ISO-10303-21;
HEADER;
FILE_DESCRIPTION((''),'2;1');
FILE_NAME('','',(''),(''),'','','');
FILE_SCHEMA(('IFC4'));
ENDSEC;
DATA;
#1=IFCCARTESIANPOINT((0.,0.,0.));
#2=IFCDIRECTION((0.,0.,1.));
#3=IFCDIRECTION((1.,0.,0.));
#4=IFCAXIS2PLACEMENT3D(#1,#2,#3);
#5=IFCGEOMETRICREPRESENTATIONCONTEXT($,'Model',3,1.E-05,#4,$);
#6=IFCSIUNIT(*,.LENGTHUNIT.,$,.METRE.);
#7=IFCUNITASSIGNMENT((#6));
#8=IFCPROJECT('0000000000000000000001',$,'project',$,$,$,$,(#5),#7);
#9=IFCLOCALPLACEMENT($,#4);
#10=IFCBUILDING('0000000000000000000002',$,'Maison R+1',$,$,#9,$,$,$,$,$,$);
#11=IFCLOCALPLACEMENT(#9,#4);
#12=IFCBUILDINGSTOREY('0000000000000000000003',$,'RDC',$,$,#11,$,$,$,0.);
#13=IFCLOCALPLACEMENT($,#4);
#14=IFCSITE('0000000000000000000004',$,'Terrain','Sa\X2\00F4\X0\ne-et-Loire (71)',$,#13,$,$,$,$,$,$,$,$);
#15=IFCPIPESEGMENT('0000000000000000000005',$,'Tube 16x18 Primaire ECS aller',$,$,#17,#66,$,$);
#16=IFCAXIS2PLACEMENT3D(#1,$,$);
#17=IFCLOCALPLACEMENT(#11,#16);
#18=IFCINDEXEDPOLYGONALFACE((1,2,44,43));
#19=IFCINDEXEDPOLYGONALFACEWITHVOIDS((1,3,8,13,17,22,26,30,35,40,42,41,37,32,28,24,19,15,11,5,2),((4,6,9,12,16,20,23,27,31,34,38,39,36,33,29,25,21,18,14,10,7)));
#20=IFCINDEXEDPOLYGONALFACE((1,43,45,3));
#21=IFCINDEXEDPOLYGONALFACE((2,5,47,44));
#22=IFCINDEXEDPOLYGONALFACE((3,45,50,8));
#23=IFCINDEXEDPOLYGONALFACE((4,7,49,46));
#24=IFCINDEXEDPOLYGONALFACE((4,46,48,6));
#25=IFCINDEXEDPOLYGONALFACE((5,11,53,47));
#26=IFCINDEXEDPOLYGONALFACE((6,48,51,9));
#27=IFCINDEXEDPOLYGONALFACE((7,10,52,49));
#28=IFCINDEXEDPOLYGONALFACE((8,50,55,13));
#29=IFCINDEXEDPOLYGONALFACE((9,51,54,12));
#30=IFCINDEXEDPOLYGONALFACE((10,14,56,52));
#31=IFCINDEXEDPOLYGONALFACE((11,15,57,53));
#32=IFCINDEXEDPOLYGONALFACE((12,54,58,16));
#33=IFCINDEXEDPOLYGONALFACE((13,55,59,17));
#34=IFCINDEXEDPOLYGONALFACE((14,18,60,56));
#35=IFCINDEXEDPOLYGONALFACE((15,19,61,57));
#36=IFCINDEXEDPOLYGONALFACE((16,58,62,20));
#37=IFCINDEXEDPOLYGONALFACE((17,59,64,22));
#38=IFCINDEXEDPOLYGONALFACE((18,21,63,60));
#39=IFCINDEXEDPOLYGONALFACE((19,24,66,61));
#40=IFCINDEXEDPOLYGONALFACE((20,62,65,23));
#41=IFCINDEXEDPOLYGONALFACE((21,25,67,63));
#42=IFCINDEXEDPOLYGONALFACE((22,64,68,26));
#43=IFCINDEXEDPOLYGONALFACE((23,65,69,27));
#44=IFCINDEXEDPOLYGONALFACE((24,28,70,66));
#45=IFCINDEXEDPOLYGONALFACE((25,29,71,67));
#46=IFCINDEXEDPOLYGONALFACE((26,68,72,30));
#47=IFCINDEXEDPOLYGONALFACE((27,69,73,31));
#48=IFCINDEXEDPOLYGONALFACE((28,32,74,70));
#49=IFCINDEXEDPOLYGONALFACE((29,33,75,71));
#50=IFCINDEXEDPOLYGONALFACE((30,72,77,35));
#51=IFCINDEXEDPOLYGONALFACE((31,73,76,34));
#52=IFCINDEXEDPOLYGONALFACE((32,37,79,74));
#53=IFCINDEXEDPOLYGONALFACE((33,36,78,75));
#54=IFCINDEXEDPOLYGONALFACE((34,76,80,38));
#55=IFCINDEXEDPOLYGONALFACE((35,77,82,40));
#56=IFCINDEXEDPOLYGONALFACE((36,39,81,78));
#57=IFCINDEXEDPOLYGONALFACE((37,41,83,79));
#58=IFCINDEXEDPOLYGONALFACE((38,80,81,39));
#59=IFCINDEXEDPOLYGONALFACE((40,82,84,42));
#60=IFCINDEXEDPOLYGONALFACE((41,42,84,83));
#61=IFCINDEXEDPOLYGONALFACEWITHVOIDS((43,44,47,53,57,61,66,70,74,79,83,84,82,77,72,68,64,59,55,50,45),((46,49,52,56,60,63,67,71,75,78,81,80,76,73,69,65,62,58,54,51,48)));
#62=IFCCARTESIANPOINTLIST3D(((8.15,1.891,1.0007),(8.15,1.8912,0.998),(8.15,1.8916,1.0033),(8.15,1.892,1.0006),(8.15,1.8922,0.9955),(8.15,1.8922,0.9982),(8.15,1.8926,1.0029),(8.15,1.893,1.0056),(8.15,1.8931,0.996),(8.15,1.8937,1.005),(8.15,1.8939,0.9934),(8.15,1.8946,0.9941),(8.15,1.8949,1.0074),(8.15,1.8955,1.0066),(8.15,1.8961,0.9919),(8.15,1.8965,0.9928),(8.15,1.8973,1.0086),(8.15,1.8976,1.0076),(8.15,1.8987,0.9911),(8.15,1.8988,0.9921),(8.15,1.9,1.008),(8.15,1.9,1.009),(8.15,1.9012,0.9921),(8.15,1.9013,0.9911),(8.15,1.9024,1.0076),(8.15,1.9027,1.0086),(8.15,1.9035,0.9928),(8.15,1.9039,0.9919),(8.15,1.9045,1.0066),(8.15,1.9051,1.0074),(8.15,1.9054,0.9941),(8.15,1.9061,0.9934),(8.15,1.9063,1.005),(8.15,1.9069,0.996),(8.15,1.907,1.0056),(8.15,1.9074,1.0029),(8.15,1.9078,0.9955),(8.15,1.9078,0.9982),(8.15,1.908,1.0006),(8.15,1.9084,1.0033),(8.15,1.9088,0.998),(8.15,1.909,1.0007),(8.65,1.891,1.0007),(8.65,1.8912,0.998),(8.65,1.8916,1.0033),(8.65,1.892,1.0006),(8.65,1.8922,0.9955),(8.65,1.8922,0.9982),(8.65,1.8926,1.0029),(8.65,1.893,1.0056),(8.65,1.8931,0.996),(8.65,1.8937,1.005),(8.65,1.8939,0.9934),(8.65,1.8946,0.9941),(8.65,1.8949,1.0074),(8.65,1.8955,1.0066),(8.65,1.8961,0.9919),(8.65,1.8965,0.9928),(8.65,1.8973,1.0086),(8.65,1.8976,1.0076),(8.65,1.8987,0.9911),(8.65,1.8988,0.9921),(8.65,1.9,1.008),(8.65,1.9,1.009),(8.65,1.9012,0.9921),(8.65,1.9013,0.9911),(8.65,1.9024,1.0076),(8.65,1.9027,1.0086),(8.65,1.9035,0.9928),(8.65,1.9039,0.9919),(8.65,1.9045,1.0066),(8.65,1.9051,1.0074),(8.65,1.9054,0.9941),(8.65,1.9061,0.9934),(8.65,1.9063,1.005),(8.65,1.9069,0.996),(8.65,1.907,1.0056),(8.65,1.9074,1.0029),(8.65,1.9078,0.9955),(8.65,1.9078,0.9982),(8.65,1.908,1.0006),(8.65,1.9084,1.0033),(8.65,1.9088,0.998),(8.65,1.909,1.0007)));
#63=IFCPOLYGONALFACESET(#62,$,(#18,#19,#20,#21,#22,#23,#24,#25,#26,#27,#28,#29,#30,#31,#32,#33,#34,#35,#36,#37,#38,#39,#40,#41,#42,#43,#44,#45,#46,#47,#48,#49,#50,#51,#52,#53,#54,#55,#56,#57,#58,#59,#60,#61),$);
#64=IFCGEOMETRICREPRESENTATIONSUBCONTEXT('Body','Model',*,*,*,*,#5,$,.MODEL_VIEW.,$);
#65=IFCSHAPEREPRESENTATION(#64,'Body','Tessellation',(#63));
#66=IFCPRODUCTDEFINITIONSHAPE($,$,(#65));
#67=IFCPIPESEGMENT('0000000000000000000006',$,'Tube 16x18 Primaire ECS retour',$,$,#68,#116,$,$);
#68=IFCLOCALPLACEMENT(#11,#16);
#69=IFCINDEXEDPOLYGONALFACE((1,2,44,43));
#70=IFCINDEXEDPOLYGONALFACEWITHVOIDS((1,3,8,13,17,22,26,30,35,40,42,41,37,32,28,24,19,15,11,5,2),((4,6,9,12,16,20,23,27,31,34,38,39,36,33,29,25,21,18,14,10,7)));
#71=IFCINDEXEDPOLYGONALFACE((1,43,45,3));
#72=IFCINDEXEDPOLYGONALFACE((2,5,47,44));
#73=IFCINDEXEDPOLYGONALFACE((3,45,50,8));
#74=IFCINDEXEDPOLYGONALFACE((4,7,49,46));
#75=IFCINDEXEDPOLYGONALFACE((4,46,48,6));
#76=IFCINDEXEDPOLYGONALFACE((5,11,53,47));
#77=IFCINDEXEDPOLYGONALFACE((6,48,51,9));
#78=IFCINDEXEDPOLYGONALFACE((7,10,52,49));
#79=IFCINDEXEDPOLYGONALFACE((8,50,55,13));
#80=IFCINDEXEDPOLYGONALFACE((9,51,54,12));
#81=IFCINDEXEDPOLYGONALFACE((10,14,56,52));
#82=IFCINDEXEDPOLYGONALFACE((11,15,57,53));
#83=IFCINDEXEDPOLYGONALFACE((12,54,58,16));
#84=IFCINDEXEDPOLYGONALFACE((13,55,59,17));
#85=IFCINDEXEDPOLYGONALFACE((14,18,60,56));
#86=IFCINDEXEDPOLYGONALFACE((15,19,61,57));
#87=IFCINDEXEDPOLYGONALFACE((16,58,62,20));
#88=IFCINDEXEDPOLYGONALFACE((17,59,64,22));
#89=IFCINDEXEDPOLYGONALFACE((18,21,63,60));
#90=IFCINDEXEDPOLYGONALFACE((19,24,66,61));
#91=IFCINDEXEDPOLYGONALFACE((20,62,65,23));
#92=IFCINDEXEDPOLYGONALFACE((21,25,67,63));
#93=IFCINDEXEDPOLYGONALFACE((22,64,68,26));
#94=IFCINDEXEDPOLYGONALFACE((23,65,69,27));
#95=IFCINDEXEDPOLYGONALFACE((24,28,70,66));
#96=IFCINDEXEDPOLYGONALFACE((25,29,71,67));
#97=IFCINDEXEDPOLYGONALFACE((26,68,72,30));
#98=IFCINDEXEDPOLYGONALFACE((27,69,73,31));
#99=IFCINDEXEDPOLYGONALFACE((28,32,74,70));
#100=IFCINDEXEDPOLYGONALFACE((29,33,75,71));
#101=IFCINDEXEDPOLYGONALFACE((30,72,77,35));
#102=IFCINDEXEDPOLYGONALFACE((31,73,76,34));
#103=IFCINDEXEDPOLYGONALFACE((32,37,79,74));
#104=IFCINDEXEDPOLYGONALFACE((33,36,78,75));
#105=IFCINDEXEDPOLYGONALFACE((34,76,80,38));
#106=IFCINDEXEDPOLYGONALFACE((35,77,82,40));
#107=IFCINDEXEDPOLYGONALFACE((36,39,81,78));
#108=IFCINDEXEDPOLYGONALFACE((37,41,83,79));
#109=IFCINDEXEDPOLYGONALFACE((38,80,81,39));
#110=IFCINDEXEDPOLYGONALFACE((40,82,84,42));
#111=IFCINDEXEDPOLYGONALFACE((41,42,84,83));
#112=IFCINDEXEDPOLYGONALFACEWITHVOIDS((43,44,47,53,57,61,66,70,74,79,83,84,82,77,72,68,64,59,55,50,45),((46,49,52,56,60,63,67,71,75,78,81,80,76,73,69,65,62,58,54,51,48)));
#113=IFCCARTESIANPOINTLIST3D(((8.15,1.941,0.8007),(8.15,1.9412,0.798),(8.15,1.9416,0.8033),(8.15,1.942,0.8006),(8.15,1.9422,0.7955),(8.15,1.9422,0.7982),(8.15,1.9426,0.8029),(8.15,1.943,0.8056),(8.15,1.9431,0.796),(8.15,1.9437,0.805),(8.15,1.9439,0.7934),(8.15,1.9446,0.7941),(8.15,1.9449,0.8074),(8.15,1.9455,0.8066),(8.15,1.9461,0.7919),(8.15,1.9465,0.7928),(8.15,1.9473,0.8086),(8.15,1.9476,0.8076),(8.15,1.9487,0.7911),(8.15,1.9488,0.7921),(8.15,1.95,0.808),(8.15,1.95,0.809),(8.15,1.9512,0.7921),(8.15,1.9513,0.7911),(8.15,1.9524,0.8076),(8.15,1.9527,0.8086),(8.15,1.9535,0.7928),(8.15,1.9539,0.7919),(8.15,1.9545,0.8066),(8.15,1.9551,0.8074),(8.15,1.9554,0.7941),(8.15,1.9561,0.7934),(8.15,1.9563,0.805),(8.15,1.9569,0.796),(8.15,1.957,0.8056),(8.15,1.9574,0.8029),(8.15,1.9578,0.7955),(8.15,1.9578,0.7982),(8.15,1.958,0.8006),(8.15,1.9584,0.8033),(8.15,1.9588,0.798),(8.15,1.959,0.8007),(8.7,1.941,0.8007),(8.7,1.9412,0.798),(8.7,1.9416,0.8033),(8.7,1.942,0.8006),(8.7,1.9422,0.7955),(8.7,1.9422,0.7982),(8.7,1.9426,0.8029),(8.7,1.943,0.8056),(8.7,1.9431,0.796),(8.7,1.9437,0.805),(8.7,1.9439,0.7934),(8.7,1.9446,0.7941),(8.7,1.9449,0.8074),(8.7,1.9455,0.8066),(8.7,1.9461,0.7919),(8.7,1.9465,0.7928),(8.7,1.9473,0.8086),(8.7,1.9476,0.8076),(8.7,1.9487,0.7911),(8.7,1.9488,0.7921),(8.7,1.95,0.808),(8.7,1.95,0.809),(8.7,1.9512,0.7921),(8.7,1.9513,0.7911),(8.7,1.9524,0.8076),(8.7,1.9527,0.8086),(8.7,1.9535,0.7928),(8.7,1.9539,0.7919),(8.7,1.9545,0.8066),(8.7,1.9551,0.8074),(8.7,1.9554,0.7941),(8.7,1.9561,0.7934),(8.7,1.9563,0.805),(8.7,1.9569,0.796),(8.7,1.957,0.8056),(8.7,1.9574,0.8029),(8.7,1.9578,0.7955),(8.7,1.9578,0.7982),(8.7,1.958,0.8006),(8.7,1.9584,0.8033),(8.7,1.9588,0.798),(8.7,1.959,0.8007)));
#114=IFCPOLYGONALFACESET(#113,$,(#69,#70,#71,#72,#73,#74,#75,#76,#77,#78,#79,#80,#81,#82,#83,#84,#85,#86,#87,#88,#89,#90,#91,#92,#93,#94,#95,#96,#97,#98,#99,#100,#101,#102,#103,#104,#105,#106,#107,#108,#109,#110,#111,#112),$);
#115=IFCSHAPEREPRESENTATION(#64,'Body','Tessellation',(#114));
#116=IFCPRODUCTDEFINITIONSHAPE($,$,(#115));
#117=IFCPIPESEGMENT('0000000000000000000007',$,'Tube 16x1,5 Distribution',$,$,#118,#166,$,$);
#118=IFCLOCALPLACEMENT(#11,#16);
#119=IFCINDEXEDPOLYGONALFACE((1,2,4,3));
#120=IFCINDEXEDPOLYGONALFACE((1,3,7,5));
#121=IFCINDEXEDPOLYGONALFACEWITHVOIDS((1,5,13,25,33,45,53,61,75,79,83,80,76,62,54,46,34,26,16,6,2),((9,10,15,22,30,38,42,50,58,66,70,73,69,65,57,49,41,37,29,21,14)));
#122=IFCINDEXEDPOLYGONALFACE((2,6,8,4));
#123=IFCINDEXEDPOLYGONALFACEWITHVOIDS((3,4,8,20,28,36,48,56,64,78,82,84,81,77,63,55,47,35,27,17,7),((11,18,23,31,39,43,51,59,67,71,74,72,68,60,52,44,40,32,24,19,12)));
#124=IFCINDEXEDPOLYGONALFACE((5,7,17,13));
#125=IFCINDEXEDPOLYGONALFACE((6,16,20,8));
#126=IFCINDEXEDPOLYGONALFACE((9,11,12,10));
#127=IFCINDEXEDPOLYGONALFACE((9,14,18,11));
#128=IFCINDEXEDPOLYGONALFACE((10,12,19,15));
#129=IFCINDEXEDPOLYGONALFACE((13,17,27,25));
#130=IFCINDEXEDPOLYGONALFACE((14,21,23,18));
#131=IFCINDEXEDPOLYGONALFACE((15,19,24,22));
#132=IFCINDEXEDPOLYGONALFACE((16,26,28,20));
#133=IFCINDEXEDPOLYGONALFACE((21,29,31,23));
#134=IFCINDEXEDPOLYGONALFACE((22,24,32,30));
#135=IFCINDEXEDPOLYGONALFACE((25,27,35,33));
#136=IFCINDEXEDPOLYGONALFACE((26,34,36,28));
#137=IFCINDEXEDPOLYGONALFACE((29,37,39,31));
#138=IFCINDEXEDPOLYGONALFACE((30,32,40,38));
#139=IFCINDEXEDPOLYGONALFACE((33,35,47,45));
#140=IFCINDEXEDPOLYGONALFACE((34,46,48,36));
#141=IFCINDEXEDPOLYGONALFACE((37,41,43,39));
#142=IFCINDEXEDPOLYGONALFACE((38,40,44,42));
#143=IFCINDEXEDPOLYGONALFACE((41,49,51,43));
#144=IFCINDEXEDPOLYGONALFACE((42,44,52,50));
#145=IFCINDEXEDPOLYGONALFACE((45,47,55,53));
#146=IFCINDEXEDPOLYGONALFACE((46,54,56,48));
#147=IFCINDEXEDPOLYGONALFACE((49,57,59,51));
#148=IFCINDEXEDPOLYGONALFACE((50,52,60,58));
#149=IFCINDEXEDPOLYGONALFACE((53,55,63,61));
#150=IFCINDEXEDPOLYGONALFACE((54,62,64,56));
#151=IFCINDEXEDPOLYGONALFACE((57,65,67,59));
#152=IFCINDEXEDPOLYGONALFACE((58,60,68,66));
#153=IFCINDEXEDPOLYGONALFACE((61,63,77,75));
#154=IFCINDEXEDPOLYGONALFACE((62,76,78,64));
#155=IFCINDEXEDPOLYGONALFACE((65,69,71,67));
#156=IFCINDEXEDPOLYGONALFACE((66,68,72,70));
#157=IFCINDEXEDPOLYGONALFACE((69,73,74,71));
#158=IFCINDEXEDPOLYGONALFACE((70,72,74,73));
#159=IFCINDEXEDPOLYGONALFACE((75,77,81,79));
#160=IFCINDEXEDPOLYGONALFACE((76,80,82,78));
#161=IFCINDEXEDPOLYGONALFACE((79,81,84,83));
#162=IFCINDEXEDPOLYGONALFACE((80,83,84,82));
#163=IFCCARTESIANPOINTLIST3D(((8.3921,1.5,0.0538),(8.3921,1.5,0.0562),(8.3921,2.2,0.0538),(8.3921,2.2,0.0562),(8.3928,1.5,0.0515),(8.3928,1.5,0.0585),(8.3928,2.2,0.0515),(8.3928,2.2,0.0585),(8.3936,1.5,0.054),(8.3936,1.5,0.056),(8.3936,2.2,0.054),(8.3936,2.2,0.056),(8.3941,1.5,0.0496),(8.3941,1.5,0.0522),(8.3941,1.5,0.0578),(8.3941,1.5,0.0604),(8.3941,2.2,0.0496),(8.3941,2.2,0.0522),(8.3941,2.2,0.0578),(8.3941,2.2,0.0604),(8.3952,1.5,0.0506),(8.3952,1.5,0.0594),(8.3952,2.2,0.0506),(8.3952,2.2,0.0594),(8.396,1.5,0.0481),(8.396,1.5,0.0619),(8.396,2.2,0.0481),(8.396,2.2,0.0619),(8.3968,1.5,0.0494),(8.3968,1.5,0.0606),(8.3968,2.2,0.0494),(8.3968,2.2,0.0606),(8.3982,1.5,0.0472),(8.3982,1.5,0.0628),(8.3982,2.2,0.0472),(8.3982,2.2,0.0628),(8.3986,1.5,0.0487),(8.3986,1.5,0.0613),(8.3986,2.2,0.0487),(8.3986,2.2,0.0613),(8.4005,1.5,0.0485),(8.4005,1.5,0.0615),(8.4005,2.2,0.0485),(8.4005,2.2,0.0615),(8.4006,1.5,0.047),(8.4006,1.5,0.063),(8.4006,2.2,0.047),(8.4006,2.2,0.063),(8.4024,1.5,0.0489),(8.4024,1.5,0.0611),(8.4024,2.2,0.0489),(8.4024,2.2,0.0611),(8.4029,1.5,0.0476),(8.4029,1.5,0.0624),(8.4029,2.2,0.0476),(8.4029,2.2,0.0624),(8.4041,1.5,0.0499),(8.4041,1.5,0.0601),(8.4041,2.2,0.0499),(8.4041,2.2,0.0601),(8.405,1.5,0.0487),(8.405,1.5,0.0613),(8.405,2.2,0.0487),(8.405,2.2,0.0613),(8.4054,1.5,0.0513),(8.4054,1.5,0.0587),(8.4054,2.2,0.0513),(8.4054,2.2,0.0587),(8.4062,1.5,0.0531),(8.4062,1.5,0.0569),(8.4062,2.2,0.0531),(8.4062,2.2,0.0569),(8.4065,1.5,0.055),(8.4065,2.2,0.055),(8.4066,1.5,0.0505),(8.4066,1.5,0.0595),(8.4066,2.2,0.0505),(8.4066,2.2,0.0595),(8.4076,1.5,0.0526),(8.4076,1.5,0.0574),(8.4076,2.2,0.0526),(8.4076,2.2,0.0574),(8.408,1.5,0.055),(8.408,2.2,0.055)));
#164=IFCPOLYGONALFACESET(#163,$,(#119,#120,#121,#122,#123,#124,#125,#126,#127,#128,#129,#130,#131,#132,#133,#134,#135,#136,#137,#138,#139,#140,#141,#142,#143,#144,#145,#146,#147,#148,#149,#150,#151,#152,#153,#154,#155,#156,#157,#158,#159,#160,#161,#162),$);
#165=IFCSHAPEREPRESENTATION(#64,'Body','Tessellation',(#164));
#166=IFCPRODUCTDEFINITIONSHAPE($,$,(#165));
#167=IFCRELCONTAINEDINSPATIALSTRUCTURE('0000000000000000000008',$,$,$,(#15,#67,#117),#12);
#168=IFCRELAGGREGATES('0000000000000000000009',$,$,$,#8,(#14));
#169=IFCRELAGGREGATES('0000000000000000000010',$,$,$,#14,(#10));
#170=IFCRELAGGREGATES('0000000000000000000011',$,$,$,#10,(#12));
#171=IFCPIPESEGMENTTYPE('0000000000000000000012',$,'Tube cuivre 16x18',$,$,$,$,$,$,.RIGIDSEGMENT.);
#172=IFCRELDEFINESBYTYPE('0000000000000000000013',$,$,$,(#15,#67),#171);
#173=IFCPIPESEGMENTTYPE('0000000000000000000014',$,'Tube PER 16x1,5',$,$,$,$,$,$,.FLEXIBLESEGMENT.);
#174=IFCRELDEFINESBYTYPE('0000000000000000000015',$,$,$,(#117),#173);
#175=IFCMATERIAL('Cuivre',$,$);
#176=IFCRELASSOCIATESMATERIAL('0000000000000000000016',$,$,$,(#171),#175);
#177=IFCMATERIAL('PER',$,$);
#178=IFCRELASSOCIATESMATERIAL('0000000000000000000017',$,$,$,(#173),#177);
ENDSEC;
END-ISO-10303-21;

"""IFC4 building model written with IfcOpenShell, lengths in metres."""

from ifc_helpers import new_model, si_unit, frame, origin_with_axes, place, context, subcontext, project, spatial, hollow_circle, extrude, material, type_object, element, save


model = new_model("IFC4")

# Units and contexts
model_context = context("Model", 3, precision=1e-05, world=origin_with_axes())
body_context = subcontext(model_context, "Body", "Model", "MODEL_VIEW")
ifc_project = project(units=[si_unit("LENGTHUNIT", "METRE")], contexts=[model_context])

# Site, building, storey
site_placement = place(None, origin_with_axes())
site = spatial("IfcSite", under=ifc_project, at=site_placement, Name="Terrain", Description="Saône-et-Loire (71)")
building_placement = place(None, origin_with_axes())
building = spatial("IfcBuilding", under=site, at=building_placement, Name="Maison R+1")
storey_placement = place(building_placement, origin_with_axes())
storey = spatial("IfcBuildingStorey", under=building, at=storey_placement, Name="RDC", Elevation=0.0)

# Pipe segments
ifc_material_1 = material(Name="Cuivre")
pipe_segment_type_1 = type_object("IfcPipeSegmentType", Name="Tube cuivre 16x18", PredefinedType="RIGIDSEGMENT", material=ifc_material_1)
pipe_segment_1_placement = place(storey_placement, frame((8.65, 1.9, 1.0), z_axis=(-1.0, 0.0, 0.0), x_axis=(0.0, 0.0, 1.0)))
element("IfcPipeSegment", 1, at=pipe_segment_1_placement, inside=storey, type_object=pipe_segment_type_1, Name="Tube 16x18 Primaire ECS aller", context=body_context, shape_type="SweptSolid", body=[
    extrude(hollow_circle(Radius=0.009, WallThickness=0.001), origin_with_axes(), (0.0, 0.0, 1.0), 0.5),
])
pipe_segment_2_placement = place(storey_placement, frame((8.7, 1.95, 0.8), z_axis=(-1.0, 0.0, 0.0), x_axis=(0.0, 0.0, 1.0)))
element("IfcPipeSegment", 2, at=pipe_segment_2_placement, inside=storey, type_object=pipe_segment_type_1, Name="Tube 16x18 Primaire ECS retour", context=body_context, shape_type="SweptSolid", body=[
    extrude(hollow_circle(Radius=0.009, WallThickness=0.001), origin_with_axes(), (0.0, 0.0, 1.0), 0.55),
])
ifc_material_2 = material(Name="PER")
pipe_segment_type_2 = type_object("IfcPipeSegmentType", Name="Tube PER 16x1,5", PredefinedType="FLEXIBLESEGMENT", material=ifc_material_2)
pipe_segment_3_placement = place(storey_placement, frame((8.4, 1.5, 0.055), z_axis=(0.0, 1.0, 0.0), x_axis=(1.0, 0.0, 0.0)))
element("IfcPipeSegment", 3, at=pipe_segment_3_placement, inside=storey, type_object=pipe_segment_type_2, Name="Tube 16x1,5 Distribution", context=body_context, shape_type="SweptSolid", body=[
    extrude(hollow_circle(Radius=0.008, WallThickness=0.0015), origin_with_axes(), (0.0, 0.0, 1.0), 0.7),
])

save(model, "model.ifc")
